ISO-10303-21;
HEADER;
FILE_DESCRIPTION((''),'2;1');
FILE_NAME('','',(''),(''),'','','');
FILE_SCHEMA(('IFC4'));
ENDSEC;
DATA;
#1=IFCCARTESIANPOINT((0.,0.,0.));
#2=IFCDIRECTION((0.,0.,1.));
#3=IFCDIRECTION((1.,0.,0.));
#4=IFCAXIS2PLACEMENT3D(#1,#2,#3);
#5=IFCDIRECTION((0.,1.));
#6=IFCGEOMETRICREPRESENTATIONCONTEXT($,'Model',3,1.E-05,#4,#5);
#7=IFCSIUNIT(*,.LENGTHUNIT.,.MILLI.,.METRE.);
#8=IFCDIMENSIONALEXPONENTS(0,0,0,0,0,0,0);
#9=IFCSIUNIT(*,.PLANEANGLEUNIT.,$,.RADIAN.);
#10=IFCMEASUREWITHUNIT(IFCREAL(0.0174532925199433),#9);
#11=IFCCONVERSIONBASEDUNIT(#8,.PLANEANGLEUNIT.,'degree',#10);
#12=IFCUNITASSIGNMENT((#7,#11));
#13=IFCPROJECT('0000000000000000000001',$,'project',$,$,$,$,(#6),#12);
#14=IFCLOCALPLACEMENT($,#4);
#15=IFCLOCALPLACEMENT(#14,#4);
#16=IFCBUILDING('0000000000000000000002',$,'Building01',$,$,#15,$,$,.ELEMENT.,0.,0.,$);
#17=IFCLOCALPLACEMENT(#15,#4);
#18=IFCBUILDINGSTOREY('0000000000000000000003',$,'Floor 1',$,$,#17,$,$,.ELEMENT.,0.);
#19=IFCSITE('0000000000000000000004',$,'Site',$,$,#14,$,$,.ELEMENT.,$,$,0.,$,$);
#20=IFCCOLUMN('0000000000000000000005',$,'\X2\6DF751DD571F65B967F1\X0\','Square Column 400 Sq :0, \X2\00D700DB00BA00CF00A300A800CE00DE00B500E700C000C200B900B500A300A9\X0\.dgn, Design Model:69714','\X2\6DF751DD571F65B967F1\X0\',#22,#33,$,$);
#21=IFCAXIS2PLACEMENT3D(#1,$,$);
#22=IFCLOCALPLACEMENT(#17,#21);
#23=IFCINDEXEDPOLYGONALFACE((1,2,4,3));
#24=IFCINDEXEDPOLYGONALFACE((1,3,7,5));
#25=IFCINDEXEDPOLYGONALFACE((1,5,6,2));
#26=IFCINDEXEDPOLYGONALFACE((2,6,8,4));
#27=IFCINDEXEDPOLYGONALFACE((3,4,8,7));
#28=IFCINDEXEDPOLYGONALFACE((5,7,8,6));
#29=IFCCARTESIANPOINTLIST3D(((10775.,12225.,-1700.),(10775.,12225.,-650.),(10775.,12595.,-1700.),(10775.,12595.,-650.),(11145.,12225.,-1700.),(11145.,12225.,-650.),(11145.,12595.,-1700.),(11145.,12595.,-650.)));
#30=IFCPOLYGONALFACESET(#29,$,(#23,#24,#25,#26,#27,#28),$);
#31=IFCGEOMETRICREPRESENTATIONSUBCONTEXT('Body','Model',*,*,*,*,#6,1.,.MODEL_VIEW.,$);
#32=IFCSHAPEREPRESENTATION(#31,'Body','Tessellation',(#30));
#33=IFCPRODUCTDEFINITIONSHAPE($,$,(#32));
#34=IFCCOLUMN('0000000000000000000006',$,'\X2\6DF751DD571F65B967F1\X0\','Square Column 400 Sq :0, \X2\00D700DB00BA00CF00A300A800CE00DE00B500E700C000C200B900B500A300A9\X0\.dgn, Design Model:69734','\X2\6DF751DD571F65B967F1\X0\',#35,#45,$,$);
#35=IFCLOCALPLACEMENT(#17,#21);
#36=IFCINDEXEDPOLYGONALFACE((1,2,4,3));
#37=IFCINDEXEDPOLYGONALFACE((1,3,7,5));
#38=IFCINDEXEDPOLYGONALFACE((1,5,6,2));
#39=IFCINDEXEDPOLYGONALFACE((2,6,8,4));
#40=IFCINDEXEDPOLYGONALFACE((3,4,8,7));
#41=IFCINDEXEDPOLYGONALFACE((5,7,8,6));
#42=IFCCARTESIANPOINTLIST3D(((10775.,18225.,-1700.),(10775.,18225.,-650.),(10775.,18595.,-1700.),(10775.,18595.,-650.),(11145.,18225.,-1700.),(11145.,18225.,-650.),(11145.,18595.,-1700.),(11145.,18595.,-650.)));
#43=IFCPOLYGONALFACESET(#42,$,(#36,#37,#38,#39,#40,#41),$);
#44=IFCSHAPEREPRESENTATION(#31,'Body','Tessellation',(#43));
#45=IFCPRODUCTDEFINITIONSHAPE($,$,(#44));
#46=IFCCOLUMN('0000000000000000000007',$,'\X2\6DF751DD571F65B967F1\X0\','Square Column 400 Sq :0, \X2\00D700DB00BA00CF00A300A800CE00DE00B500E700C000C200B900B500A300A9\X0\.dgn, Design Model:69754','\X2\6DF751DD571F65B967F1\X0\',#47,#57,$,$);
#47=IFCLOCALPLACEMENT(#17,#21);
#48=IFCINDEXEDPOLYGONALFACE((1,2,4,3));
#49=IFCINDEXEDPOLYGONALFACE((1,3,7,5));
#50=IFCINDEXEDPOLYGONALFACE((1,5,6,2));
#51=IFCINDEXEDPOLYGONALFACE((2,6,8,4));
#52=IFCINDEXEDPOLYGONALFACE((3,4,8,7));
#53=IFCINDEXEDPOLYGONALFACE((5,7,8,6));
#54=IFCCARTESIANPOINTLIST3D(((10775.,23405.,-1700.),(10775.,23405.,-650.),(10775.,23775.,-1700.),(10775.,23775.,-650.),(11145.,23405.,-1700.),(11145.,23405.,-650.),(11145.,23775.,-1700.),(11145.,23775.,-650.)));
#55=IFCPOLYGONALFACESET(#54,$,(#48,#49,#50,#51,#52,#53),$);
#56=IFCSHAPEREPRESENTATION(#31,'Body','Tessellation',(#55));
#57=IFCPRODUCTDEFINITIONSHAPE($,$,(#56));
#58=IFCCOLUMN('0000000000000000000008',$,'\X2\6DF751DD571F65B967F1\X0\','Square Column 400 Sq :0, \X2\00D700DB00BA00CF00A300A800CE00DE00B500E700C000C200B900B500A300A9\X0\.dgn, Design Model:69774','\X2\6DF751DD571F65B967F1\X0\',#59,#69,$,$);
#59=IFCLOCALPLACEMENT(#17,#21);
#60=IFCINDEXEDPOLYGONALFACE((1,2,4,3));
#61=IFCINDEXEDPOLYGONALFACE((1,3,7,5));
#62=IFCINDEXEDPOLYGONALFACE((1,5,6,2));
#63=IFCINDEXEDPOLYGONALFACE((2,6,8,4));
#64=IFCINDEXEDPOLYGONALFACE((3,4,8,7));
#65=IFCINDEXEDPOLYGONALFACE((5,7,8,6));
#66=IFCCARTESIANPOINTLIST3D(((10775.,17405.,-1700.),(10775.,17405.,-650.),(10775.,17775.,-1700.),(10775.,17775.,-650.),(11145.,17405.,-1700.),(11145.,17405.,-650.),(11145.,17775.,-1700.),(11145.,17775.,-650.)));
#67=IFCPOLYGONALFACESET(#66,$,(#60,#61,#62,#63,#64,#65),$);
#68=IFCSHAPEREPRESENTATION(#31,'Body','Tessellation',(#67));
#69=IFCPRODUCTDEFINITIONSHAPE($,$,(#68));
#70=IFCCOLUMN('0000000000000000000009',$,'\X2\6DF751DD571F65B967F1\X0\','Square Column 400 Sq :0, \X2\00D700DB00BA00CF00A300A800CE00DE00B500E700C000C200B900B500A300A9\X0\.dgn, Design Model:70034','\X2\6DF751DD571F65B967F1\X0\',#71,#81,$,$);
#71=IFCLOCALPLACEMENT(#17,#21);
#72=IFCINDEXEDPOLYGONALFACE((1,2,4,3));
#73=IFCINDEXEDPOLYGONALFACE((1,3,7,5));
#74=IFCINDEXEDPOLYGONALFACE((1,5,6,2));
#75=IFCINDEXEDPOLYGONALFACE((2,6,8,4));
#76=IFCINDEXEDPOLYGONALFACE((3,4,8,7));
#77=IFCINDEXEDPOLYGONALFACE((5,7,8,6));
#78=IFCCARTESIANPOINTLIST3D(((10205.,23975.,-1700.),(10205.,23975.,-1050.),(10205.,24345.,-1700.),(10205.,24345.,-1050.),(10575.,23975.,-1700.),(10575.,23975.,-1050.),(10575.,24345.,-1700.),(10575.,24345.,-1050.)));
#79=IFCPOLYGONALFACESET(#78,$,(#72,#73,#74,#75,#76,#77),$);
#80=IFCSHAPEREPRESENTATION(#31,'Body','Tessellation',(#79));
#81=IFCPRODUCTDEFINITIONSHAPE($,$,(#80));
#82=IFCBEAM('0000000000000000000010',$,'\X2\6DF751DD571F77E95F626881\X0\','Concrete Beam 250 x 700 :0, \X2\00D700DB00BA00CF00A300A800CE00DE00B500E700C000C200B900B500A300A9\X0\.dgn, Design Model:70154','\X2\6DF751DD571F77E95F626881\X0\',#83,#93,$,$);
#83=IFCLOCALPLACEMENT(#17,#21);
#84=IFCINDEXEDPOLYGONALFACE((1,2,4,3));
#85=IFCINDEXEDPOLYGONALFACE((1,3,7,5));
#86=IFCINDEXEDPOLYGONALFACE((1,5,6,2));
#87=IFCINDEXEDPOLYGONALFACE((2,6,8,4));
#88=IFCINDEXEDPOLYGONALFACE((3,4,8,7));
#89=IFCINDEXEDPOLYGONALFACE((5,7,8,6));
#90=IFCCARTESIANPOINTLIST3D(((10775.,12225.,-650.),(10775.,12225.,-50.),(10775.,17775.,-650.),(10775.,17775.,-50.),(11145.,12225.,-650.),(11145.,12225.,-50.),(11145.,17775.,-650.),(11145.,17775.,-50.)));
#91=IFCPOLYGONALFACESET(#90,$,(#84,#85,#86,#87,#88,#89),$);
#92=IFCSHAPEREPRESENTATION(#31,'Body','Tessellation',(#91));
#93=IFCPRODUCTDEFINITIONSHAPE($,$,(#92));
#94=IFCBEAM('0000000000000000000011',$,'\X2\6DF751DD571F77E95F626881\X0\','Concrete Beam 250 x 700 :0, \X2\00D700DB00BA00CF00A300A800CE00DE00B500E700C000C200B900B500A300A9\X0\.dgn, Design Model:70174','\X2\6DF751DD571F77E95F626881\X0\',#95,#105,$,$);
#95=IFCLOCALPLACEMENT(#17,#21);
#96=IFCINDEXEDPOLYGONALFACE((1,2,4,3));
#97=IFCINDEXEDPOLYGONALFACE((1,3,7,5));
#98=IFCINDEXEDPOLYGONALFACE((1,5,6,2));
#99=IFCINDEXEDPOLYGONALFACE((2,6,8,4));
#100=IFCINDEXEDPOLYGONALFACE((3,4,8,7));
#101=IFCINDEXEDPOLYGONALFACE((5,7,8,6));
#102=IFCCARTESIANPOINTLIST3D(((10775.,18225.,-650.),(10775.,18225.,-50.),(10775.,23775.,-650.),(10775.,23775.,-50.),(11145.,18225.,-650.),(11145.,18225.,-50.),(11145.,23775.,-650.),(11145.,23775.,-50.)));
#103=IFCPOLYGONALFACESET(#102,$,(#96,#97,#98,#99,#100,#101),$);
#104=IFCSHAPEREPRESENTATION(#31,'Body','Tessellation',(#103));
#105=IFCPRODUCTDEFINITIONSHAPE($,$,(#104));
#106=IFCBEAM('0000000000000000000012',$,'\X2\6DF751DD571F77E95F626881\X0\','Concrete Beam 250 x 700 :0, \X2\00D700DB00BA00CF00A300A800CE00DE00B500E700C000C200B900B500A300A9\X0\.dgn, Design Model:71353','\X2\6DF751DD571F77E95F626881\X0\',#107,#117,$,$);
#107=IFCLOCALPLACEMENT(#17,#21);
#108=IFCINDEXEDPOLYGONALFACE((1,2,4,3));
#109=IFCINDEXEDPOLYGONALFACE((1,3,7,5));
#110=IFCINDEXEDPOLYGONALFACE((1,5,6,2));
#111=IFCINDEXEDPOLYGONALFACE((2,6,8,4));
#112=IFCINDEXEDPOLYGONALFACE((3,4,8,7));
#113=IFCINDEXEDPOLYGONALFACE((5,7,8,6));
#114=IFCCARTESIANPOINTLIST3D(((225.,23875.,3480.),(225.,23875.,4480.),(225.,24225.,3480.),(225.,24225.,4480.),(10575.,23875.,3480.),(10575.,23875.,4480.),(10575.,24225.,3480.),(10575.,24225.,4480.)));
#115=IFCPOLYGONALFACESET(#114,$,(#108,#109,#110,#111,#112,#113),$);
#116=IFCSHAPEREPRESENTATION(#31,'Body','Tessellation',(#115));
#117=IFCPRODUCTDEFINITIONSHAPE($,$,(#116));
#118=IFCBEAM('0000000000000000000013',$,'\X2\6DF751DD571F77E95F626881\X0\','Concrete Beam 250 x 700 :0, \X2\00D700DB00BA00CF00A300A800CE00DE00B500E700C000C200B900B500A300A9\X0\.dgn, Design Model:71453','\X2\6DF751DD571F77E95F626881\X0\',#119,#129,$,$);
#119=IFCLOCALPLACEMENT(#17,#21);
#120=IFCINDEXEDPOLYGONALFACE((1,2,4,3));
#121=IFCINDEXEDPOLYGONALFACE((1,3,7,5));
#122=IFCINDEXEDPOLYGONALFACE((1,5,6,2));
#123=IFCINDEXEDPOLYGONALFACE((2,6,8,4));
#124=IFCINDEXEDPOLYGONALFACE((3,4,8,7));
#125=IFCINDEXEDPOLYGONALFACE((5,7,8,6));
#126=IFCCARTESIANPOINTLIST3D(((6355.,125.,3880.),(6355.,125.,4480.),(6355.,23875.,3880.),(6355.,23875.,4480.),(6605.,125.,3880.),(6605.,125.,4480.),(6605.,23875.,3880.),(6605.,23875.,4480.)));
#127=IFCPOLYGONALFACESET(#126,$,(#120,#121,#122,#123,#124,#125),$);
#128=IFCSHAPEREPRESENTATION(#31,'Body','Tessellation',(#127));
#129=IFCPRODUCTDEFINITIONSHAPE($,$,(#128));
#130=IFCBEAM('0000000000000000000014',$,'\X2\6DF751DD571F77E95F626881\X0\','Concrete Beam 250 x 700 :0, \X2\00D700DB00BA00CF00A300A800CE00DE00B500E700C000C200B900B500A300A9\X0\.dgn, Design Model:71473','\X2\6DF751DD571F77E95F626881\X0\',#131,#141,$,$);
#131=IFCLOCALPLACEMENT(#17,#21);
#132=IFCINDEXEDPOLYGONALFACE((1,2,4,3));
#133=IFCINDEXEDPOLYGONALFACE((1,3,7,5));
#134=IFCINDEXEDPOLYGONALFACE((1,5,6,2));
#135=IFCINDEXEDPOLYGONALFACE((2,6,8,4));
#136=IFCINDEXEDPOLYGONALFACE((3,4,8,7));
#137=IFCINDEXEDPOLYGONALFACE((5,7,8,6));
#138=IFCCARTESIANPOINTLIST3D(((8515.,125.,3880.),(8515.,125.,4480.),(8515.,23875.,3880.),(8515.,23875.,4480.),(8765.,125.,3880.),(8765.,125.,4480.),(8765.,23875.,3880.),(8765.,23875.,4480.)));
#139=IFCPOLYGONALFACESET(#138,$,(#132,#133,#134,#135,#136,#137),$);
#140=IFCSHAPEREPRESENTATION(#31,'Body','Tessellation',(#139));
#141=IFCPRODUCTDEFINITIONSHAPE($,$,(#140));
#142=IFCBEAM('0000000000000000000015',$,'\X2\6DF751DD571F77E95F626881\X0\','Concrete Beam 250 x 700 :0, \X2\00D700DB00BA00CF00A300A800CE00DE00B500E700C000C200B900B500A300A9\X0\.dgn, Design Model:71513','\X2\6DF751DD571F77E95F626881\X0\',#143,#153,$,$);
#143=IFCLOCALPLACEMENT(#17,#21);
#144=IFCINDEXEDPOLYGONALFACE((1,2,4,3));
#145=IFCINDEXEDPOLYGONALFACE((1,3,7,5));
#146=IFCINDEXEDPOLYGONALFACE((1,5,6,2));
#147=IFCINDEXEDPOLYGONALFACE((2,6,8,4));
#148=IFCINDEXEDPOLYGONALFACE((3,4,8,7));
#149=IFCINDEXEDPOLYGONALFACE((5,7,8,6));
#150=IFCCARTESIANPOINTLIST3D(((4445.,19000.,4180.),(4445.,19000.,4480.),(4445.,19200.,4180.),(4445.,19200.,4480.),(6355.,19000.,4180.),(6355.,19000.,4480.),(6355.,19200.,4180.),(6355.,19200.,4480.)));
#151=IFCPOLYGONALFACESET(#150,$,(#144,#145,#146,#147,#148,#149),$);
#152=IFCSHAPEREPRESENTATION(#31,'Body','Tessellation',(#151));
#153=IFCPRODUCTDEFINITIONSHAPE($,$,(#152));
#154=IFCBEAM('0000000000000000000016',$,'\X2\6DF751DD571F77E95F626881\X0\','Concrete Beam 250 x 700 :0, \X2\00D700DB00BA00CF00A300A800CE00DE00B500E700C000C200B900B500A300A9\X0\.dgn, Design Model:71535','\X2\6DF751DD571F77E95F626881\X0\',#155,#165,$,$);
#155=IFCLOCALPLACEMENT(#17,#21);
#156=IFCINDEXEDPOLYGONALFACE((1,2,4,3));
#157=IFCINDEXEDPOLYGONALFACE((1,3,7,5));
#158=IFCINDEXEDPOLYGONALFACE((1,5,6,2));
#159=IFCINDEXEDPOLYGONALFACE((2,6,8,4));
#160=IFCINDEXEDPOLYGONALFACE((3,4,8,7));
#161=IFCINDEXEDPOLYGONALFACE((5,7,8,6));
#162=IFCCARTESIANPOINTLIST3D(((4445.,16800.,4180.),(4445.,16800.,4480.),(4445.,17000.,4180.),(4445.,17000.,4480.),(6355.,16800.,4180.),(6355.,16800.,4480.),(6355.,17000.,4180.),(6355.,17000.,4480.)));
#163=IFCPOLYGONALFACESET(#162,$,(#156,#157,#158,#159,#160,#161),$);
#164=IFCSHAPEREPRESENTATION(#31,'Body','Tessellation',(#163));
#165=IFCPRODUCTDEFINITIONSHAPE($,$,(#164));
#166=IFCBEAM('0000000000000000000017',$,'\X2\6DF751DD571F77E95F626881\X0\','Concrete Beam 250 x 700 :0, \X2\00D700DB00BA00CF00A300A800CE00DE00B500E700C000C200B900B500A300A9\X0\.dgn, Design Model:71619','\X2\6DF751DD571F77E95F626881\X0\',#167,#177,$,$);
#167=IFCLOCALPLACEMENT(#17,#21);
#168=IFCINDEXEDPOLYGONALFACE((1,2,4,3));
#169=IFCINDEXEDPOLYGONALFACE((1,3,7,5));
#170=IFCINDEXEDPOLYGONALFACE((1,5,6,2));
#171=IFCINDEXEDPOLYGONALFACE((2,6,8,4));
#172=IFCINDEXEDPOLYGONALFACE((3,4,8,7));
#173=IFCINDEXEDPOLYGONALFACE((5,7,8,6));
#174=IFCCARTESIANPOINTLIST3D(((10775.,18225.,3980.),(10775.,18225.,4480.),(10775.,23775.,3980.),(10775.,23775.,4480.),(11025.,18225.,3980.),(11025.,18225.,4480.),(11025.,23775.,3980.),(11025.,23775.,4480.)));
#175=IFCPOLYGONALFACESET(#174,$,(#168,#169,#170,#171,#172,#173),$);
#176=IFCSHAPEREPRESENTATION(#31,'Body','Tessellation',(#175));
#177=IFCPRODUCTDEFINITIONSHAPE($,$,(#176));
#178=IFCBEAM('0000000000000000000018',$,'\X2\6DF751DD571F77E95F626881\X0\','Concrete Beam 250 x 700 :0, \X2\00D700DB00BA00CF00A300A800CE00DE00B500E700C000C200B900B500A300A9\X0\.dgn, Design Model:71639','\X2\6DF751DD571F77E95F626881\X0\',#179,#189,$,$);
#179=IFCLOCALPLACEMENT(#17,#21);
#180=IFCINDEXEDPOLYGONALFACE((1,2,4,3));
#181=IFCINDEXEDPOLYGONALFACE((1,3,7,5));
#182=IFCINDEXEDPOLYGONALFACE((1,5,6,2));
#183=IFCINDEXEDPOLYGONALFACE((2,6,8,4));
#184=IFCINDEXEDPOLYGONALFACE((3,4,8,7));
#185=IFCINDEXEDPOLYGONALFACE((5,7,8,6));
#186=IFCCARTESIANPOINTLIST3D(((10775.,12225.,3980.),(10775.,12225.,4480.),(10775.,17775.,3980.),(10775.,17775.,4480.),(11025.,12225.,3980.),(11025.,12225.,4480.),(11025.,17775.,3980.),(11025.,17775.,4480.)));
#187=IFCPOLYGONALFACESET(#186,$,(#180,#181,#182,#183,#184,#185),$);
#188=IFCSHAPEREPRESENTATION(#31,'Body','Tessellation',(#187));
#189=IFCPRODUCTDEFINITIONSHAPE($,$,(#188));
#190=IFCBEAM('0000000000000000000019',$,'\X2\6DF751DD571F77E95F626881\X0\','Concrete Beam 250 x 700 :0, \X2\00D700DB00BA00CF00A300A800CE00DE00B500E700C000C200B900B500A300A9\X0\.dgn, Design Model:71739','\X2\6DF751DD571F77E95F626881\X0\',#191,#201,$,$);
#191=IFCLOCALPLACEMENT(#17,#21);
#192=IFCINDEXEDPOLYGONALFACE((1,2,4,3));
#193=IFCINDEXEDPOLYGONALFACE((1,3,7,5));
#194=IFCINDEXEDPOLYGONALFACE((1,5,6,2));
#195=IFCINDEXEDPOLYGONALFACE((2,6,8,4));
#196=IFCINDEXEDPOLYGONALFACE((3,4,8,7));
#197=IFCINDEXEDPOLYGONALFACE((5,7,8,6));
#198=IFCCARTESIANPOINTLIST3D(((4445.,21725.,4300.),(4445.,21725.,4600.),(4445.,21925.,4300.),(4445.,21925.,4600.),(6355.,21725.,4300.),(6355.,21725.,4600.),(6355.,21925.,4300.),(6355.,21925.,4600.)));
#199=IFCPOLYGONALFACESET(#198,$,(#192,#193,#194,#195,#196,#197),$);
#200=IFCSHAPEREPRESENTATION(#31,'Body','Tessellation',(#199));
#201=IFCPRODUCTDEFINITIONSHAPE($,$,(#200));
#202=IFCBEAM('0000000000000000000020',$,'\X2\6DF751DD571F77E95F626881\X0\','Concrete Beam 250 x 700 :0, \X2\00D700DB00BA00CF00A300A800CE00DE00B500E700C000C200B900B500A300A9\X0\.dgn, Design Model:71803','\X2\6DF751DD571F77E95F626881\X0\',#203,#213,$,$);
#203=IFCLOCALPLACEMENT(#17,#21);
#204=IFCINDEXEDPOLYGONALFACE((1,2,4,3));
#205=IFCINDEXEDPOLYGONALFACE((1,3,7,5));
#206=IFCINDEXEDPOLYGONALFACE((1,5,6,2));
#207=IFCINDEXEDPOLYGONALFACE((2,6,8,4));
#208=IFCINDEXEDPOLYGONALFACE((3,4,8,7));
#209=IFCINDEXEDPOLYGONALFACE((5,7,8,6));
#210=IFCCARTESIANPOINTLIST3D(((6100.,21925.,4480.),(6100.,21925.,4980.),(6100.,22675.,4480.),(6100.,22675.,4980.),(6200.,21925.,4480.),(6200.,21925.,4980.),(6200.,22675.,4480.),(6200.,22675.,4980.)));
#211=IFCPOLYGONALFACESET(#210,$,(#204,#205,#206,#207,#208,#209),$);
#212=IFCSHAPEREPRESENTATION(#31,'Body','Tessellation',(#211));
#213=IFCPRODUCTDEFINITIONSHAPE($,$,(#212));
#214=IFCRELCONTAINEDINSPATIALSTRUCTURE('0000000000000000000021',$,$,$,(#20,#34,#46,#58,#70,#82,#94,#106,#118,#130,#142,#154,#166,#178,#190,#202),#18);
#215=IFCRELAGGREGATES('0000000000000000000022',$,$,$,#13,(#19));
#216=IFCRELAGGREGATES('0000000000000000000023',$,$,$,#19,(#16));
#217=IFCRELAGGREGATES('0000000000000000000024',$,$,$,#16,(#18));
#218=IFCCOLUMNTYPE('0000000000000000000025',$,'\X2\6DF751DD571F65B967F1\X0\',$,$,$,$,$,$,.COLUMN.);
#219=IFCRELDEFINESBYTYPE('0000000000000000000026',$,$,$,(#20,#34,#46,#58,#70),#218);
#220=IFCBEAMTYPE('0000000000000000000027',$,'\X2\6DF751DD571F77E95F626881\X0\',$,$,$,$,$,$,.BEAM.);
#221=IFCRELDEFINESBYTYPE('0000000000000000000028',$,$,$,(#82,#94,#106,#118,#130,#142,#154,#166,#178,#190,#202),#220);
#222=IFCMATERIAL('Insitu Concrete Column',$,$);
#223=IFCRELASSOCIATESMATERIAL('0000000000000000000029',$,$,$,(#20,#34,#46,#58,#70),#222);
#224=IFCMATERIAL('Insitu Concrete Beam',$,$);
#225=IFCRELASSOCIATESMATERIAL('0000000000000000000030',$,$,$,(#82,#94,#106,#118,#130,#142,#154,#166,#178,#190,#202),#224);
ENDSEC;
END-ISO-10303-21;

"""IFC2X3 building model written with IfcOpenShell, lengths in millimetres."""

from ifc_helpers import new_model, entity, si_unit, converted_unit, direction, frame, frame_2d, origin_with_axes, place, context, subcontext, project, spatial, rectangle, extrude, material, type_object, element, save


model = new_model("IFC2X3")

# Units and contexts
model_context = context("Model", 3, precision=1e-05, world=origin_with_axes(), true_north=direction((0.0, 1.0)))
body_context = subcontext(model_context, "Body", "Model", "MODEL_VIEW", scale=1.0)
ifc_project = project(units=[si_unit("LENGTHUNIT", "METRE", prefix="MILLI"), converted_unit("PLANEANGLEUNIT", "degree", entity("IfcReal", 0.0174532925199433), si_unit("PLANEANGLEUNIT", "RADIAN"), dimensions=[0, 0, 0, 0, 0, 0, 0])], contexts=[model_context])

# Site, building, storey
site_placement = place(None, origin_with_axes())
site = spatial("IfcSite", under=ifc_project, at=site_placement, Name="Site", CompositionType="ELEMENT", RefElevation=0.0)
building_placement = place(site_placement, origin_with_axes())
building = spatial("IfcBuilding", under=site, at=building_placement, Name="Building01", CompositionType="ELEMENT", ElevationOfRefHeight=0.0, ElevationOfTerrain=0.0)
storey_placement = place(building_placement, origin_with_axes())
storey = spatial("IfcBuildingStorey", under=building, at=storey_placement, Name="Floor 1", CompositionType="ELEMENT", Elevation=0.0)

# Columns
ifc_material_1 = material(Name="Insitu Concrete Column")
column_type = type_object("IfcColumnType", Name="混凝土方柱", PredefinedType="COLUMN")
for number, where, z_axis, x_axis, name, description in (
    (1, (10775.0, 12595.0, -1700.0), (0.0, 0.0, 1.0), (0.0, -1.0, 0.0), "混凝土方柱", "Square Column 400 Sq :0, ×ÛºÏ£¨ÎÞµçÀÂ¹µ£©.dgn, Design Model:69714"),
    (2, (10775.0, 18595.0, -1700.0), (0.0, 0.0, 1.0), (0.0, -1.0, 0.0), "混凝土方柱", "Square Column 400 Sq :0, ×ÛºÏ£¨ÎÞµçÀÂ¹µ£©.dgn, Design Model:69734"),
    (3, (10775.0, 23405.0, -1700.0), (0.0, 0.0, 1.0), (1.0, 0.0, 0.0), "混凝土方柱", "Square Column 400 Sq :0, ×ÛºÏ£¨ÎÞµçÀÂ¹µ£©.dgn, Design Model:69754"),
    (4, (10775.0, 17405.0, -1700.0), (0.0, 0.0, 1.0), (1.0, 0.0, 0.0), "混凝土方柱", "Square Column 400 Sq :0, ×ÛºÏ£¨ÎÞµçÀÂ¹µ£©.dgn, Design Model:69774"),
):
    element("IfcColumn", number, at=place(storey_placement, frame(where, z_axis=z_axis, x_axis=x_axis)), inside=storey, type_object=column_type, material=ifc_material_1, Name=name, Description=description, ObjectType="混凝土方柱", context=body_context, shape_type="SweptSolid", body=[
        extrude(rectangle(XDim=370.0, YDim=370.0, at=frame_2d((185.0, 185.0), x_axis=(0.0, 1.0))), origin_with_axes(), (0.0, 0.0, 1.0), 1050.0),
    ])
column_placement = place(storey_placement, frame((10575.0, 23975.0, -1700.0), z_axis=(0.0, 0.0, 1.0), x_axis=(0.0, 1.0, 0.0)))
element("IfcColumn", 5, at=column_placement, inside=storey, type_object=column_type, material=ifc_material_1, Name="混凝土方柱", Description="Square Column 400 Sq :0, ×ÛºÏ£¨ÎÞµçÀÂ¹µ£©.dgn, Design Model:70034", ObjectType="混凝土方柱", context=body_context, shape_type="SweptSolid", body=[
    extrude(rectangle(XDim=370.0, YDim=370.0, at=frame_2d((185.0, 185.0), x_axis=(0.0, 1.0))), origin_with_axes(), (0.0, 0.0, 1.0), 650.0),
])

# Beams
ifc_material_2 = material(Name="Insitu Concrete Beam")
beam_type = type_object("IfcBeamType", Name="混凝土矩形梁", PredefinedType="BEAM")
for number, where, z_axis, x_axis, name, description in (
    (6, (11145.0, 12225.0, -650.0), (0.0, 1.0, 0.0), (-1.0, 0.0, 0.0), "混凝土矩形梁", "Concrete Beam 250 x 700 :0, ×ÛºÏ£¨ÎÞµçÀÂ¹µ£©.dgn, Design Model:70154"),
    (7, (11145.0, 18225.0, -650.0), (0.0, 1.0, 0.0), (-1.0, 0.0, 0.0), "混凝土矩形梁", "Concrete Beam 250 x 700 :0, ×ÛºÏ£¨ÎÞµçÀÂ¹µ£©.dgn, Design Model:70174"),
):
    element("IfcBeam", number, at=place(storey_placement, frame(where, z_axis=z_axis, x_axis=x_axis)), inside=storey, type_object=beam_type, material=ifc_material_2, Name=name, Description=description, ObjectType="混凝土矩形梁", context=body_context, shape_type="SweptSolid", body=[
        extrude(rectangle(XDim=600.0, YDim=370.0, at=frame_2d((185.0, 300.0), x_axis=(0.0, 1.0))), origin_with_axes(), (0.0, 0.0, 1.0), 5550.0),
    ])
beam_1_placement = place(storey_placement, frame((10575.0, 24225.0, 3480.0), z_axis=(-1.0, 0.0, 0.0), x_axis=(0.0, -1.0, 0.0)))
element("IfcBeam", 8, at=beam_1_placement, inside=storey, type_object=beam_type, material=ifc_material_2, Name="混凝土矩形梁", Description="Concrete Beam 250 x 700 :0, ×ÛºÏ£¨ÎÞµçÀÂ¹µ£©.dgn, Design Model:71353", ObjectType="混凝土矩形梁", context=body_context, shape_type="SweptSolid", body=[
    extrude(rectangle(XDim=1000.0, YDim=350.0, at=frame_2d((175.0, 500.0), x_axis=(0.0, 1.0))), origin_with_axes(), (0.0, 0.0, 1.0), 10350.0),
])
for number, where, z_axis, x_axis, name, description in (
    (9, (6355.0, 23875.0, 3880.0), (0.0, -1.0, 0.0), (1.0, 0.0, 0.0), "混凝土矩形梁", "Concrete Beam 250 x 700 :0, ×ÛºÏ£¨ÎÞµçÀÂ¹µ£©.dgn, Design Model:71453"),
    (10, (8515.0, 23875.0, 3880.0), (0.0, -1.0, 0.0), (1.0, 0.0, 0.0), "混凝土矩形梁", "Concrete Beam 250 x 700 :0, ×ÛºÏ£¨ÎÞµçÀÂ¹µ£©.dgn, Design Model:71473"),
):
    element("IfcBeam", number, at=place(storey_placement, frame(where, z_axis=z_axis, x_axis=x_axis)), inside=storey, type_object=beam_type, material=ifc_material_2, Name=name, Description=description, ObjectType="混凝土矩形梁", context=body_context, shape_type="SweptSolid", body=[
        extrude(rectangle(XDim=600.0, YDim=250.0, at=frame_2d((125.0, 300.0), x_axis=(0.0, 1.0))), origin_with_axes(), (0.0, 0.0, 1.0), 23750.0),
    ])
for number, where, z_axis, x_axis, name, description in (
    (11, (6355.0, 19200.0, 4180.0), (-1.0, 0.0, 0.0), (0.0, -1.0, 0.0), "混凝土矩形梁", "Concrete Beam 250 x 700 :0, ×ÛºÏ£¨ÎÞµçÀÂ¹µ£©.dgn, Design Model:71513"),
    (12, (6355.0, 17000.0, 4180.0), (-1.0, 0.0, 0.0), (0.0, -1.0, 0.0), "混凝土矩形梁", "Concrete Beam 250 x 700 :0, ×ÛºÏ£¨ÎÞµçÀÂ¹µ£©.dgn, Design Model:71535"),
):
    element("IfcBeam", number, at=place(storey_placement, frame(where, z_axis=z_axis, x_axis=x_axis)), inside=storey, type_object=beam_type, material=ifc_material_2, Name=name, Description=description, ObjectType="混凝土矩形梁", context=body_context, shape_type="SweptSolid", body=[
        extrude(rectangle(XDim=300.0, YDim=200.0, at=frame_2d((100.0, 150.0), x_axis=(0.0, 1.0))), origin_with_axes(), (0.0, 0.0, 1.0), 1910.0),
    ])
for number, where, z_axis, x_axis, name, description in (
    (13, (10775.0, 23775.0, 3980.0), (0.0, -1.0, 0.0), (1.0, 0.0, 0.0), "混凝土矩形梁", "Concrete Beam 250 x 700 :0, ×ÛºÏ£¨ÎÞµçÀÂ¹µ£©.dgn, Design Model:71619"),
    (14, (10775.0, 17775.0, 3980.0), (0.0, -1.0, 0.0), (1.0, 0.0, 0.0), "混凝土矩形梁", "Concrete Beam 250 x 700 :0, ×ÛºÏ£¨ÎÞµçÀÂ¹µ£©.dgn, Design Model:71639"),
):
    element("IfcBeam", number, at=place(storey_placement, frame(where, z_axis=z_axis, x_axis=x_axis)), inside=storey, type_object=beam_type, material=ifc_material_2, Name=name, Description=description, ObjectType="混凝土矩形梁", context=body_context, shape_type="SweptSolid", body=[
        extrude(rectangle(XDim=500.0, YDim=250.0, at=frame_2d((125.0, 250.0), x_axis=(0.0, 1.0))), origin_with_axes(), (0.0, 0.0, 1.0), 5550.0),
    ])
beam_2_placement = place(storey_placement, frame((6355.0, 21925.0, 4300.0), z_axis=(-1.0, 0.0, 0.0), x_axis=(0.0, -1.0, 0.0)))
element("IfcBeam", 15, at=beam_2_placement, inside=storey, type_object=beam_type, material=ifc_material_2, Name="混凝土矩形梁", Description="Concrete Beam 250 x 700 :0, ×ÛºÏ£¨ÎÞµçÀÂ¹µ£©.dgn, Design Model:71739", ObjectType="混凝土矩形梁", context=body_context, shape_type="SweptSolid", body=[
    extrude(rectangle(XDim=300.0, YDim=200.0, at=frame_2d((100.0, 150.0), x_axis=(0.0, 1.0))), origin_with_axes(), (0.0, 0.0, 1.0), 1910.0),
])
beam_3_placement = place(storey_placement, frame((6200.0, 21925.0, 4480.0), z_axis=(0.0, 1.0, 0.0), x_axis=(-1.0, 0.0, 0.0)))
element("IfcBeam", 16, at=beam_3_placement, inside=storey, type_object=beam_type, material=ifc_material_2, Name="混凝土矩形梁", Description="Concrete Beam 250 x 700 :0, ×ÛºÏ£¨ÎÞµçÀÂ¹µ£©.dgn, Design Model:71803", ObjectType="混凝土矩形梁", context=body_context, shape_type="SweptSolid", body=[
    extrude(rectangle(XDim=500.0, YDim=100.0, at=frame_2d((50.0, 250.0), x_axis=(0.0, 1.0))), origin_with_axes(), (0.0, 0.0, 1.0), 750.0),
])

save(model, "model.ifc")
